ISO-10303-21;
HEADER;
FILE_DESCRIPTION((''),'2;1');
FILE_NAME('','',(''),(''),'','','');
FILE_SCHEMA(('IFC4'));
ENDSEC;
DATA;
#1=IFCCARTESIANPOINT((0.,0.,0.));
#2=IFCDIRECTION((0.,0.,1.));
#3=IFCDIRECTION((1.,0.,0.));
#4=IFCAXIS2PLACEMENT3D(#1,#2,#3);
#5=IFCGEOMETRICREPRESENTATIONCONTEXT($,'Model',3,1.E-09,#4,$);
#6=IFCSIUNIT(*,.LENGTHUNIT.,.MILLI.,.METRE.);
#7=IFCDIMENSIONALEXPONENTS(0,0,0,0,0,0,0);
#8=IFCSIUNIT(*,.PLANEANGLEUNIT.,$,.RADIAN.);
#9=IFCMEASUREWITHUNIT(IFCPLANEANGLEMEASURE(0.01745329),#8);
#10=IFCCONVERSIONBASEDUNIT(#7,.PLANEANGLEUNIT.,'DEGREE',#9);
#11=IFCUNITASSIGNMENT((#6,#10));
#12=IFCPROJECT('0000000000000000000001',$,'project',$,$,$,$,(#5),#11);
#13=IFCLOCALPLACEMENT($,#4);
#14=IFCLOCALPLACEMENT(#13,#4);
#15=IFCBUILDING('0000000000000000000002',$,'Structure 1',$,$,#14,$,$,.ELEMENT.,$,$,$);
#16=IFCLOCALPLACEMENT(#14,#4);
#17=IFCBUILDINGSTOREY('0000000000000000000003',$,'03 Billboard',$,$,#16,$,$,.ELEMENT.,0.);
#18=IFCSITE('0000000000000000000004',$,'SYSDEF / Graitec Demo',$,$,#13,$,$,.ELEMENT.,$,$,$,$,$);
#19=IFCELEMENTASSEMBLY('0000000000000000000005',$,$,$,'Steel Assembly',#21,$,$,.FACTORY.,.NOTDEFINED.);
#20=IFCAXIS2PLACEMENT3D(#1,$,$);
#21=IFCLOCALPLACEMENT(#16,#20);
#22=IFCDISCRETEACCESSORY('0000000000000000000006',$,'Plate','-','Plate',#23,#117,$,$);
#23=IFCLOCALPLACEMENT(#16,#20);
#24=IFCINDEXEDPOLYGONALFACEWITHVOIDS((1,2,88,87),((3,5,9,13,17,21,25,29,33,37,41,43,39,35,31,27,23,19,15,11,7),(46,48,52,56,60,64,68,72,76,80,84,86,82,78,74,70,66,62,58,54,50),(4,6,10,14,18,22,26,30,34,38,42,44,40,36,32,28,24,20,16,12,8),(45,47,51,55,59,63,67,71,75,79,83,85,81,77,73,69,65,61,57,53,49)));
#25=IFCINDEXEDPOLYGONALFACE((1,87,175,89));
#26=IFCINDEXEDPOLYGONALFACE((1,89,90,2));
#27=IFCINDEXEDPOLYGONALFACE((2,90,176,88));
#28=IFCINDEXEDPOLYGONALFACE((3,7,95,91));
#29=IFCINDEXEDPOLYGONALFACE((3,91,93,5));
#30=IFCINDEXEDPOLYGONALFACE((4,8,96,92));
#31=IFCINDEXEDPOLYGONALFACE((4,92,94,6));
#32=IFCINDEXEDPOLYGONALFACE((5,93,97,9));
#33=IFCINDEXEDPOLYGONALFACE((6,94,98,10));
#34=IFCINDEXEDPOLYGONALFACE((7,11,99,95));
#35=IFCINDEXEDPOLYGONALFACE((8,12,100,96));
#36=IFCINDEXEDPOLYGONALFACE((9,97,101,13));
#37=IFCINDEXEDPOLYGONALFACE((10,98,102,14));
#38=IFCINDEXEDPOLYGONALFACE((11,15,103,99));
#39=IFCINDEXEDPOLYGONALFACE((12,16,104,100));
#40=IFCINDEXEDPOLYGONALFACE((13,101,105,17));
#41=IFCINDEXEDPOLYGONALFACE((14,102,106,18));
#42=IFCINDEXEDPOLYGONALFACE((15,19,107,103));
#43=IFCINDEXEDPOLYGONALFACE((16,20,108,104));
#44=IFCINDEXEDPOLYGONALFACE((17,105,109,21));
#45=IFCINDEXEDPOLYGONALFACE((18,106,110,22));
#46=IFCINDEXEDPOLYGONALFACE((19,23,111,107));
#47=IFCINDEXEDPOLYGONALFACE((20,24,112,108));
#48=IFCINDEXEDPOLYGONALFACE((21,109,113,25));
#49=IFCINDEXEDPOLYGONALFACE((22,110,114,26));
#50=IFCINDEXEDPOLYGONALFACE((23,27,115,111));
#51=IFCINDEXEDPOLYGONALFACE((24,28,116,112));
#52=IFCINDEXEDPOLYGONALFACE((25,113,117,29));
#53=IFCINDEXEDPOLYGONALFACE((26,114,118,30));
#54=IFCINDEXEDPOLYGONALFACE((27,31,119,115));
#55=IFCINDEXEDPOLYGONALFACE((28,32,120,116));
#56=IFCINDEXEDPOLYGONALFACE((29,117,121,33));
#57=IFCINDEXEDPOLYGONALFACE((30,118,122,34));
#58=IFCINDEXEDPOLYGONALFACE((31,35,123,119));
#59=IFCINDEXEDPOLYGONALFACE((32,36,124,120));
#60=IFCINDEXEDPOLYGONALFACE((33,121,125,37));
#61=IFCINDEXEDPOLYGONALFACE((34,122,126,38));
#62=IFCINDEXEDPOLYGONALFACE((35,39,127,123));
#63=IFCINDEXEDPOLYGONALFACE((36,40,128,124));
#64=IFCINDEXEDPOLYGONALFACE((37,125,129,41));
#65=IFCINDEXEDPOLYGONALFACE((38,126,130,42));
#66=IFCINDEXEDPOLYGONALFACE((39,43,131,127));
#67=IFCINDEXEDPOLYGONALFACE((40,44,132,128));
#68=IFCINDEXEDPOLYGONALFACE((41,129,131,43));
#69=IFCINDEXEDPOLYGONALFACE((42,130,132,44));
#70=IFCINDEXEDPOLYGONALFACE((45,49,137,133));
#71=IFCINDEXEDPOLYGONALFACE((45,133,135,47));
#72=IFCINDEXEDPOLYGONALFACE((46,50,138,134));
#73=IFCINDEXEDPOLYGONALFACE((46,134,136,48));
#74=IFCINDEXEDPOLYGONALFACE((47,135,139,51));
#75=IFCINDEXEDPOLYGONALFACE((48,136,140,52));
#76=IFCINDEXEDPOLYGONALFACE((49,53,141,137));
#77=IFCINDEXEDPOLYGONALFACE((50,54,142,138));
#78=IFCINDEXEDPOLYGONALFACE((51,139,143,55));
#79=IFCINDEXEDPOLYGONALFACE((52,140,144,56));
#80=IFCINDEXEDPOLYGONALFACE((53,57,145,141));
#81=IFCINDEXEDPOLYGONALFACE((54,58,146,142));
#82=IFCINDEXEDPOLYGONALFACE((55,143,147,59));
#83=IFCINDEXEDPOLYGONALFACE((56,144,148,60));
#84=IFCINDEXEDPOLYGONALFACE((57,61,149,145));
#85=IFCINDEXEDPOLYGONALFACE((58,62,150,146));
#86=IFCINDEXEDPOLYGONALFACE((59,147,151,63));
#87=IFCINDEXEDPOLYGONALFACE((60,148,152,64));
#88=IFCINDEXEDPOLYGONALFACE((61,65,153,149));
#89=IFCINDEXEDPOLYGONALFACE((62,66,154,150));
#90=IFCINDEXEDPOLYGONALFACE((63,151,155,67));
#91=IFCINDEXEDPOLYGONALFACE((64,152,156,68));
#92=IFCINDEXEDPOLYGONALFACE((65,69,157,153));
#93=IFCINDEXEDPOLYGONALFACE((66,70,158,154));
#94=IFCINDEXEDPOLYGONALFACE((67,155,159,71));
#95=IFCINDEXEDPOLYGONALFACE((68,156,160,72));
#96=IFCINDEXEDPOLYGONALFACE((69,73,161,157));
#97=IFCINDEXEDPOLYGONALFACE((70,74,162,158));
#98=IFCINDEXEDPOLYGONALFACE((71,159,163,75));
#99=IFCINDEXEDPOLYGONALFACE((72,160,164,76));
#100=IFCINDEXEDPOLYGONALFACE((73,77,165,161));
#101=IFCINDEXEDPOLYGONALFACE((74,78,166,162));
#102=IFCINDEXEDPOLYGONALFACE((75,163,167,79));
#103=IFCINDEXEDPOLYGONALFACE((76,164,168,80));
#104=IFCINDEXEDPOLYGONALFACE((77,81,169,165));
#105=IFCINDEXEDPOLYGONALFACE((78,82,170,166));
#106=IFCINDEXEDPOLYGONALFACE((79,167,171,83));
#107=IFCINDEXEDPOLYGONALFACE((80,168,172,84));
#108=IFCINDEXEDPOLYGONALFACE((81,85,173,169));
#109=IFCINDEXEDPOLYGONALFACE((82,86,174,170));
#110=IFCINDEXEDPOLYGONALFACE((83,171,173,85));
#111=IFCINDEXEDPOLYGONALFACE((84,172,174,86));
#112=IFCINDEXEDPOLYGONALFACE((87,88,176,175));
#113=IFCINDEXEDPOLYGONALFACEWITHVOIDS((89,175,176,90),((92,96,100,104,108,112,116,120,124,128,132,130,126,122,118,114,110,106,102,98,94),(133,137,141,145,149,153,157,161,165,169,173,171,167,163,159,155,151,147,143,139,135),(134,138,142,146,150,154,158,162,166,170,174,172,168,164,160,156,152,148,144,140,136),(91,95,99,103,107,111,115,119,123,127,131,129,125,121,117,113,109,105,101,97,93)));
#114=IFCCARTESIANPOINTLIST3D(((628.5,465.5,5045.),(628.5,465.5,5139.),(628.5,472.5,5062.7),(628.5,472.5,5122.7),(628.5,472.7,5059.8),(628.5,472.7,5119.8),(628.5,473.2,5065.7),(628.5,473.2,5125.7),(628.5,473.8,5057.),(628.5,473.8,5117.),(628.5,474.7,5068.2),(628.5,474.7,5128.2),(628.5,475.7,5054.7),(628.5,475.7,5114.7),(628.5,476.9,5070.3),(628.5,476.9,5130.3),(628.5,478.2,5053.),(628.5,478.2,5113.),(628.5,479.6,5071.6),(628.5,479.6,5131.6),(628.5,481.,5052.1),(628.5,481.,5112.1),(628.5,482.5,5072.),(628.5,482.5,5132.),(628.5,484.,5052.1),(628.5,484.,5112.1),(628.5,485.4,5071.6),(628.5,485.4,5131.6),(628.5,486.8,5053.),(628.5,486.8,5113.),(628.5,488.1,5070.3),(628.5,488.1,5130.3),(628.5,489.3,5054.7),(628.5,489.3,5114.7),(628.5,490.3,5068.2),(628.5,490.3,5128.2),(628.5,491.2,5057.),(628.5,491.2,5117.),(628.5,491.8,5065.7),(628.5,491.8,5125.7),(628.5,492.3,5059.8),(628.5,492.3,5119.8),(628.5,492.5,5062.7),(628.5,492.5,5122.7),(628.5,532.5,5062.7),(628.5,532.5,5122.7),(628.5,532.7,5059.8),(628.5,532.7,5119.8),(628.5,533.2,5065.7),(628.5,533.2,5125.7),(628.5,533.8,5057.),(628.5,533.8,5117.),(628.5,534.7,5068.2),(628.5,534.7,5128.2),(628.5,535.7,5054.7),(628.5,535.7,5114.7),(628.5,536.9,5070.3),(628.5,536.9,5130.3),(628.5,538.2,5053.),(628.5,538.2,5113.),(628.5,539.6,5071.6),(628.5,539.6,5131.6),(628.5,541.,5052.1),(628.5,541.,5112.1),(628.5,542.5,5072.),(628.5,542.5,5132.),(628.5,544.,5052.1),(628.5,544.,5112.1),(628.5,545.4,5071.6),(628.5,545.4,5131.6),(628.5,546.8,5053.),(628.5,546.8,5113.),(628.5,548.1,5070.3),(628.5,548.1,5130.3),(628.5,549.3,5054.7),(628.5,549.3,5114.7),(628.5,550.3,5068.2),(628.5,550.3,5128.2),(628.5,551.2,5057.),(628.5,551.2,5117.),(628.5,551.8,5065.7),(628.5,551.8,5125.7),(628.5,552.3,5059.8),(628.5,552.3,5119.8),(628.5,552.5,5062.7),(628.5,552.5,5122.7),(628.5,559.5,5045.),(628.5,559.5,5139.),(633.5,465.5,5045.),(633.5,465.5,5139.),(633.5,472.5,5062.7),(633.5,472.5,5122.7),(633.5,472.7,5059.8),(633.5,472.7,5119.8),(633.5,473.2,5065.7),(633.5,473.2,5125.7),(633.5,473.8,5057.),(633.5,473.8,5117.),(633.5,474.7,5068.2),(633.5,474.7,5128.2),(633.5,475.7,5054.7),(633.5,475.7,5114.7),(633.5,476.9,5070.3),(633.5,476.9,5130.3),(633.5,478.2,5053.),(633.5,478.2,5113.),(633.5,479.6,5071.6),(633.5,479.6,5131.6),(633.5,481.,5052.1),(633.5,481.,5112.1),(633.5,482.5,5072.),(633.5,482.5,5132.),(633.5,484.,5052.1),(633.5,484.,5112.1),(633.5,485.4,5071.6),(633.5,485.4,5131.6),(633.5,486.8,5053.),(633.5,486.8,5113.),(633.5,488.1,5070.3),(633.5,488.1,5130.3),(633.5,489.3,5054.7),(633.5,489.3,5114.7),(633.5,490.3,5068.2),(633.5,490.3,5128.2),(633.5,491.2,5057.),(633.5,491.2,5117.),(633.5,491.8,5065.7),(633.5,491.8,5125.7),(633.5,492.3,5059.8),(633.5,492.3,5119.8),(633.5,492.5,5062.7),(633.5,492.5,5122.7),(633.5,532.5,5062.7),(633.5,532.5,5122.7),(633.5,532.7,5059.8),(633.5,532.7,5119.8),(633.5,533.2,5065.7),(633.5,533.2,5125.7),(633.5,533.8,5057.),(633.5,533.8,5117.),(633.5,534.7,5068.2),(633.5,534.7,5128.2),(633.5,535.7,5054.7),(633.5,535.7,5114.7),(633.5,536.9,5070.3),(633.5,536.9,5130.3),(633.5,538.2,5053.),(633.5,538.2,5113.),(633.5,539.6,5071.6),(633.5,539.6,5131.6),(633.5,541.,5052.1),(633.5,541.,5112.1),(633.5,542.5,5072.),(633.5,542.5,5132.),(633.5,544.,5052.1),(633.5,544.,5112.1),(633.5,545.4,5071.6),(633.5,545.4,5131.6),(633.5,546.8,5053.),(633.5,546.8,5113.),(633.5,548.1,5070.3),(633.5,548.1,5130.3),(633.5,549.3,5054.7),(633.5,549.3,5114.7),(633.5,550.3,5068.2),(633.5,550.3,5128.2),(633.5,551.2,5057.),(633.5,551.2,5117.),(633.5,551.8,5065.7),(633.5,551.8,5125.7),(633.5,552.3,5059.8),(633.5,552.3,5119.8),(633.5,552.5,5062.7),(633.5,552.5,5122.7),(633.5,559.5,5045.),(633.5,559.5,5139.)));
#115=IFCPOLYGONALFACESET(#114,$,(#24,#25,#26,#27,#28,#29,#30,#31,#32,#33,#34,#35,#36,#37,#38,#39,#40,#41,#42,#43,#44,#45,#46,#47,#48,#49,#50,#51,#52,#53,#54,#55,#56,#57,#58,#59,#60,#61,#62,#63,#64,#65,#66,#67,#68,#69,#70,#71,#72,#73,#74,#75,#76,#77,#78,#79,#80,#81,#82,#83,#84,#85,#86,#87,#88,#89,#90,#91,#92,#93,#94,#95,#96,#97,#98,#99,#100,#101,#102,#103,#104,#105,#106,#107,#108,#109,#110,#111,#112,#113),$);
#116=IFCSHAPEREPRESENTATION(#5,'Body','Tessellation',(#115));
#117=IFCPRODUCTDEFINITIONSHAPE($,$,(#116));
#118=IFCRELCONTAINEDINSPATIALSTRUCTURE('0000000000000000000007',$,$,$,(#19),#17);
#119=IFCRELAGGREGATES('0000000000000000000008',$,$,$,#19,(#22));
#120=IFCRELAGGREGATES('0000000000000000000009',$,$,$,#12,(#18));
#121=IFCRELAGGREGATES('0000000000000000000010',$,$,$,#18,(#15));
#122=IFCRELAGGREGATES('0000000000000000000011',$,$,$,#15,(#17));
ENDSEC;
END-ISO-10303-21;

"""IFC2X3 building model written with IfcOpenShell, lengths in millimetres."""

from ifc_helpers import new_model, entity, si_unit, converted_unit, frame, frame_2d, origin, origin_with_axes, place, context, project, spatial, polyline, circle, outline, extrude, element, aggregate, save


model = new_model("IFC2X3")

# Units and contexts
model_context = context("Model", 3, precision=1e-09, world=origin_with_axes())
ifc_project = project(units=[si_unit("LENGTHUNIT", "METRE", prefix="MILLI"), converted_unit("PLANEANGLEUNIT", "DEGREE", entity("IfcPlaneAngleMeasure", 0.01745329), si_unit("PLANEANGLEUNIT", "RADIAN"), dimensions=[0, 0, 0, 0, 0, 0, 0])], contexts=[model_context])

# Site, building, storey
site_placement = place(None, origin_with_axes())
site = spatial("IfcSite", under=ifc_project, at=site_placement, Name="SYSDEF / Graitec Demo", CompositionType="ELEMENT")
building_placement = place(site_placement, origin_with_axes())
building = spatial("IfcBuilding", under=site, at=building_placement, Name="Structure 1", CompositionType="ELEMENT")
storey_placement = place(building_placement, origin_with_axes())
storey = spatial("IfcBuildingStorey", under=building, at=storey_placement, Name="03 Billboard", CompositionType="ELEMENT", Elevation=0.0)

# Element assembly
assembly_1_placement = place(None, frame((546.0, 433.5, 3973.6), z_axis=(0.0, 0.0, 1.0), x_axis=(0.0, 1.0, 0.0)))
assembly_1 = element("IfcElementAssembly", 1, at=assembly_1_placement, inside=storey, ObjectType="Steel Assembly", AssemblyPlace="FACTORY", PredefinedType="NOTDEFINED")

# Discrete accessory, openings
discrete_accessory_1_placement = place(assembly_1_placement, frame((79.0, -87.5, 1118.4), z_axis=(0.000002, -1.0, 0.0), x_axis=(0.0, 0.0, 1.0)))
discrete_accessory_1 = element("IfcDiscreteAccessory", 2, at=discrete_accessory_1_placement, Name="Plate", Description="-", ObjectType="Plate", context=model_context, shape_type="SweptSolid", body=[
    extrude(outline(polyline([(-47.0, -47.0), (47.0, -47.0), (47.0, 47.0), (-47.0, 47.0), (-47.0, -47.0)])), origin_with_axes(), (0.0, 0.0, -1.0), 5.0),
])
opening_1_placement = place(discrete_accessory_1_placement, frame((-40.0, 30.0, 0.5), z_axis=(0.0, 0.0, 1.0), x_axis=(1.0, 0.0, 0.0)))
element("IfcOpeningElement", 3, at=opening_1_placement, cuts=discrete_accessory_1, ObjectType="Opening", context=model_context, shape_type="SweptSolid", body=[
    extrude(circle(Radius=10.0, at=frame_2d((10.0, 0.0), x_axis=(1.0, 0.0))), origin(), (0.0, 0.0, -1.0), 6.0),
])
opening_2_placement = place(discrete_accessory_1_placement, frame((-40.0, -30.0, 0.5), z_axis=(0.0, 0.0, 1.0), x_axis=(1.0, 0.0, 0.0)))
element("IfcOpeningElement", 4, at=opening_2_placement, cuts=discrete_accessory_1, ObjectType="Opening", context=model_context, shape_type="SweptSolid", body=[
    extrude(circle(Radius=10.0, at=frame_2d((10.0, 0.0), x_axis=(1.0, 0.0))), origin(), (0.0, 0.0, -1.0), 6.0),
])
opening_3_placement = place(discrete_accessory_1_placement, frame((20.0, 30.0, 0.5), z_axis=(0.0, 0.0, 1.0), x_axis=(1.0, 0.0, 0.0)))
element("IfcOpeningElement", 5, at=opening_3_placement, cuts=discrete_accessory_1, ObjectType="Opening", context=model_context, shape_type="SweptSolid", body=[
    extrude(circle(Radius=10.0, at=frame_2d((10.0, 0.0), x_axis=(1.0, 0.0))), origin(), (0.0, 0.0, -1.0), 6.0),
])
opening_4_placement = place(discrete_accessory_1_placement, frame((20.0, -30.0, 0.5), z_axis=(0.0, 0.0, 1.0), x_axis=(1.0, 0.0, 0.0)))
element("IfcOpeningElement", 6, at=opening_4_placement, cuts=discrete_accessory_1, ObjectType="Opening", context=model_context, shape_type="SweptSolid", body=[
    extrude(circle(Radius=10.0, at=frame_2d((10.0, 0.0), x_axis=(1.0, 0.0))), origin(), (0.0, 0.0, -1.0), 6.0),
])
aggregate(assembly_1, [discrete_accessory_1])

save(model, "model.ifc")
